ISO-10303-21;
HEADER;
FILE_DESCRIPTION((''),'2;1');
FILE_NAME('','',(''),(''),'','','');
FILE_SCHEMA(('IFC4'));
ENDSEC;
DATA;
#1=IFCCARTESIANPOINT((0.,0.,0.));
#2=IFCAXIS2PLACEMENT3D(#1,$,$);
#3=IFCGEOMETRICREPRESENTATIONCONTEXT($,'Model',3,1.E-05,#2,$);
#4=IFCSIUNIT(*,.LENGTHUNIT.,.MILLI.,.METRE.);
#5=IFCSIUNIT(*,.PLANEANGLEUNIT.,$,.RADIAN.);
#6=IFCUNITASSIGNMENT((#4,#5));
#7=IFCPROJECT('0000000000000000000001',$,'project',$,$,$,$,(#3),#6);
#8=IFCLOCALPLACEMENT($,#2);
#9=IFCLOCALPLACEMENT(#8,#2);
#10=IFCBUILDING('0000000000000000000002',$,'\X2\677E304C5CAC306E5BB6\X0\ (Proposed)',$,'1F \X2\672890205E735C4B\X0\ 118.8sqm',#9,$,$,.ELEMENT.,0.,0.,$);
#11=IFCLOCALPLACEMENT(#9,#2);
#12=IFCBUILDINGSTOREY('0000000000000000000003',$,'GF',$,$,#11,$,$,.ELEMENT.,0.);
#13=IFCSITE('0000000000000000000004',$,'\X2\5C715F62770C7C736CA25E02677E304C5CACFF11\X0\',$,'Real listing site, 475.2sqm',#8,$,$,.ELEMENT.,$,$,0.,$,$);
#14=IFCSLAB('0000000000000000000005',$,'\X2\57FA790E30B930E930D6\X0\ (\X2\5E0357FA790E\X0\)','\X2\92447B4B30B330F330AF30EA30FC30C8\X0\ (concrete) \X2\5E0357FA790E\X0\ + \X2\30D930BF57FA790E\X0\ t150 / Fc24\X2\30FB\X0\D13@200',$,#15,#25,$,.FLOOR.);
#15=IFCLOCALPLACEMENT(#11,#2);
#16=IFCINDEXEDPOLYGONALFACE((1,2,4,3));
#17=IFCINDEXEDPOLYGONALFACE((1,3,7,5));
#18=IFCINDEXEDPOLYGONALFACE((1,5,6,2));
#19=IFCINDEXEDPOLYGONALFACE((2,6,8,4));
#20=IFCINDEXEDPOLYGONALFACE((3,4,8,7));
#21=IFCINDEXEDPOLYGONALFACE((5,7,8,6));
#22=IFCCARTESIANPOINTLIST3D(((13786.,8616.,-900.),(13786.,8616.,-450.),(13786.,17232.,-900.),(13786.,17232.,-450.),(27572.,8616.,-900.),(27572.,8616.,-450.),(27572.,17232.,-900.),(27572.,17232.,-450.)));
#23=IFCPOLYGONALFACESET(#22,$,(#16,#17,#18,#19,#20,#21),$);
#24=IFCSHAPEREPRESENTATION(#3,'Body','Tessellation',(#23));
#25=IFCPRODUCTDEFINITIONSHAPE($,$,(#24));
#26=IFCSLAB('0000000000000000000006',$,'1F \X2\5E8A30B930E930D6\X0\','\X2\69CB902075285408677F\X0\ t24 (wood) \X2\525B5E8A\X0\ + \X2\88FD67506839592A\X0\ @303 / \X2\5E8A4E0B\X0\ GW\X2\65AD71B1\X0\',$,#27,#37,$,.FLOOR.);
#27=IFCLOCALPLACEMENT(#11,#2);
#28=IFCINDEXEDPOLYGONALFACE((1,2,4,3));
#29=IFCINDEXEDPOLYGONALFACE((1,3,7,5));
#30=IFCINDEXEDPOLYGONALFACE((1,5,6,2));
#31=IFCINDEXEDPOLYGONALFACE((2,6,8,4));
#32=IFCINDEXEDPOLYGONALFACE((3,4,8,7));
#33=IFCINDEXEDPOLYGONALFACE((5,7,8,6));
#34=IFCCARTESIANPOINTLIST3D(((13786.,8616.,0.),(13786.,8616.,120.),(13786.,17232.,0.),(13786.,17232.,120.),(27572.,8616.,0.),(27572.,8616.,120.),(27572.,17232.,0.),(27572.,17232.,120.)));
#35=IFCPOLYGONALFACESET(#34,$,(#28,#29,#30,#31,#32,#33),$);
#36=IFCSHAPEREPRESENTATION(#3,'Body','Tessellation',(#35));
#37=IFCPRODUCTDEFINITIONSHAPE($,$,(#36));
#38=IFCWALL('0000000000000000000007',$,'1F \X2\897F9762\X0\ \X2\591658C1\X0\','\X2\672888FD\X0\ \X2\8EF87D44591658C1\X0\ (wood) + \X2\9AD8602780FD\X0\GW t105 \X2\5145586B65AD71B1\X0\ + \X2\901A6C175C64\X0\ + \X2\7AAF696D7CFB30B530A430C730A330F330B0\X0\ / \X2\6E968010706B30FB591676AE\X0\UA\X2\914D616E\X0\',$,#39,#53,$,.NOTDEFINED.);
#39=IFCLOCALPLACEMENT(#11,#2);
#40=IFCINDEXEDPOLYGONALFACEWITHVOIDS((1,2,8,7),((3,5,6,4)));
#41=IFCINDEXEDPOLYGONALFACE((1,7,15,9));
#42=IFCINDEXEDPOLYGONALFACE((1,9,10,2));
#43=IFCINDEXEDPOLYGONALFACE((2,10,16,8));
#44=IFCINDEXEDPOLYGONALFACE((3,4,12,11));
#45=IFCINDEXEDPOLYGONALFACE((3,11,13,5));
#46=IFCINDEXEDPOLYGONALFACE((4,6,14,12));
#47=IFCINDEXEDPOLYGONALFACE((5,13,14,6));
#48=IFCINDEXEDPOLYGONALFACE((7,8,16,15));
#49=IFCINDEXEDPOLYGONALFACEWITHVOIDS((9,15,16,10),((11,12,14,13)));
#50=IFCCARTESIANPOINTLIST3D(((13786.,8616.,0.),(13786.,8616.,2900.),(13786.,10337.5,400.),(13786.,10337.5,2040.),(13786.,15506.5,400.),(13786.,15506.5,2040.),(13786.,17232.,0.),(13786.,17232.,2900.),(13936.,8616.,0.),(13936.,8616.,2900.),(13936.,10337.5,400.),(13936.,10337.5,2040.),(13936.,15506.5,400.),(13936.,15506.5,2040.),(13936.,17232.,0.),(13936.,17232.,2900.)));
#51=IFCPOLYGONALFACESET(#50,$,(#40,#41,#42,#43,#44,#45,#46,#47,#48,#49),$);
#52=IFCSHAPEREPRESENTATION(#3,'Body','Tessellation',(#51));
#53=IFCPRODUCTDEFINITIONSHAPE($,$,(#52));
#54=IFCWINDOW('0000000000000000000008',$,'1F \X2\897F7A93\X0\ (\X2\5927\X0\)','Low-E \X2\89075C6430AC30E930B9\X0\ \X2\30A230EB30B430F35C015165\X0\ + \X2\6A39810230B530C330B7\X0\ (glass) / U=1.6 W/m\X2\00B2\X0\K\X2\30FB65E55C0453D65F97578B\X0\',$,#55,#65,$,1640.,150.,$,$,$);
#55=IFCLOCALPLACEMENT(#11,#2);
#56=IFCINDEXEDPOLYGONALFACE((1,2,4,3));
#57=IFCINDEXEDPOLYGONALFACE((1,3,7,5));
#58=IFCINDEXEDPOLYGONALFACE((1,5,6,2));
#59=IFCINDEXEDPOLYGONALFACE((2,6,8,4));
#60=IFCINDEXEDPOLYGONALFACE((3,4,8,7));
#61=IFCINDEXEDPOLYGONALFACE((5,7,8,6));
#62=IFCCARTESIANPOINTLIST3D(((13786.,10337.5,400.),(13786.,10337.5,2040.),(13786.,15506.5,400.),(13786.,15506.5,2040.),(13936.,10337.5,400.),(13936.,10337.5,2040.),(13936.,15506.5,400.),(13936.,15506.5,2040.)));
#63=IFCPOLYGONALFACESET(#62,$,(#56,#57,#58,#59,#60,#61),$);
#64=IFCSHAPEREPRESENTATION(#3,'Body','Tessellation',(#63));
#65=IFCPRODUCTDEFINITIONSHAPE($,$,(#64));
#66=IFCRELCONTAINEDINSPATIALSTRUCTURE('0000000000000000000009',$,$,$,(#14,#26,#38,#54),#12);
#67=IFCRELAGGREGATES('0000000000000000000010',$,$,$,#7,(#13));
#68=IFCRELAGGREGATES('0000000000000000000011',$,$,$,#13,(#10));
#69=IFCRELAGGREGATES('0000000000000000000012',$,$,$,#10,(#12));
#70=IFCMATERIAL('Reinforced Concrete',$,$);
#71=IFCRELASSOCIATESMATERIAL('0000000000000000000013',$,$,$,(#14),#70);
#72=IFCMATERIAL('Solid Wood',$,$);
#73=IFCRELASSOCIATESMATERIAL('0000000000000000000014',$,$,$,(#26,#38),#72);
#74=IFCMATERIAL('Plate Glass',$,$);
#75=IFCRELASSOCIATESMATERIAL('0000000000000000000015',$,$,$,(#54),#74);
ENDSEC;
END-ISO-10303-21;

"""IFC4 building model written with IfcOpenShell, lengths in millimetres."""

from ifc_helpers import new_model, si_unit, frame, frame_2d, origin, place, context, project, spatial, rectangle, extrude, material, element, fill, save


model = new_model("IFC4")

# Units and contexts
model_context = context("Model", 3, precision=1e-05, world=origin())
ifc_project = project(units=[si_unit("LENGTHUNIT", "METRE", prefix="MILLI"), si_unit("PLANEANGLEUNIT", "RADIAN")], contexts=[model_context])

# Site, building, storey
site_placement = place(None, origin())
site = spatial("IfcSite", under=ifc_project, at=site_placement, Name="山形県米沢市松が岬１", ObjectType="Real listing site, 475.2sqm", CompositionType="ELEMENT", RefElevation=0.0)
building_placement = place(site_placement, origin())
building = spatial("IfcBuilding", under=site, at=building_placement, Name="松が岬の家 (Proposed)", ObjectType="1F 木造平屋 118.8sqm", CompositionType="ELEMENT", ElevationOfRefHeight=0.0, ElevationOfTerrain=0.0)
storey_placement = place(building_placement, origin())
storey = spatial("IfcBuildingStorey", under=building, at=storey_placement, Name="GF", CompositionType="ELEMENT", Elevation=0.0)

# Slabs
ifc_material_1 = material(Name="Reinforced Concrete")
slab_1_placement = place(storey_placement, frame((6893.0, 4308.0, -450.0)))
element("IfcSlab", 1, at=slab_1_placement, inside=storey, material=ifc_material_1, Name="基礎スラブ (布基礎)", Description="鉄筋コンクリート (concrete) 布基礎 + ベタ基礎 t150 / Fc24・D13@200", PredefinedType="FLOOR", context=model_context, shape_type="SweptSolid", body=[
    extrude(rectangle(XDim=13786.0, YDim=8616.0, at=frame_2d((6893.0, 4308.0))), frame((6893.0, 4308.0, -450.0)), (0.0, 0.0, 1.0), 450.0),
])
ifc_material_2 = material(Name="Solid Wood")
slab_2_placement = place(storey_placement, frame((6893.0, 4308.0, 0.0)))
element("IfcSlab", 2, at=slab_2_placement, inside=storey, material=ifc_material_2, Name="1F 床スラブ", Description="構造用合板 t24 (wood) 剛床 + 製材根太 @303 / 床下 GW断熱", PredefinedType="FLOOR", context=model_context, shape_type="SweptSolid", body=[
    extrude(rectangle(XDim=13786.0, YDim=8616.0, at=frame_2d((6893.0, 4308.0))), frame((6893.0, 4308.0, 0.0)), (0.0, 0.0, 1.0), 120.0),
])

# Shared definitions
ifc_material_3 = material(Name="Plate Glass")

# Wall, opening, window
wall_1_placement = place(storey_placement, frame((6893.0, 4308.0, 0.0)))
wall_1 = element("IfcWall", 3, at=wall_1_placement, inside=storey, material=ifc_material_2, Name="1F 西面 外壁", Description="木製 軸組外壁 (wood) + 高性能GW t105 充填断熱 + 通気層 + 窯業系サイディング / 準耐火・外皮UA配慮", PredefinedType="NOTDEFINED", context=model_context, shape_type="SweptSolid", body=[
    extrude(rectangle(XDim=150.0, YDim=8616.0, at=frame_2d((75.0, 4308.0))), frame((6893.0, 4308.0, 0.0)), (0.0, 0.0, 1.0), 2900.0),
])
opening_1_placement = place(storey_placement, frame((6893.0, 5169.0, 200.0)))
opening_1 = element("IfcOpeningElement", 4, at=opening_1_placement, cuts=wall_1, PredefinedType="NOTDEFINED", context=model_context, shape_type="SweptSolid", body=[
    extrude(rectangle(XDim=150.0, YDim=5169.0, at=frame_2d((75.0, 2584.0))), frame((6893.0, 5169.0, 200.0)), (0.0, 0.0, 1.0), 1640.0),
])
window_1_placement = place(storey_placement, frame((6893.0, 5169.0, 200.0)))
window_1 = element("IfcWindow", 5, at=window_1_placement, inside=storey, material=ifc_material_3, Name="1F 西窓 (大)", Description="Low-E 複層ガラス アルゴン封入 + 樹脂サッシ (glass) / U=1.6 W/m²K・日射取得型", OverallHeight=1640.0, OverallWidth=150.0, context=model_context, shape_type="SweptSolid", body=[
    extrude(rectangle(XDim=150.0, YDim=5169.0, at=frame_2d((75.0, 2584.0))), frame((6893.0, 5169.0, 200.0)), (0.0, 0.0, 1.0), 1640.0),
])
fill(opening_1, window_1)

save(model, "model.ifc")
